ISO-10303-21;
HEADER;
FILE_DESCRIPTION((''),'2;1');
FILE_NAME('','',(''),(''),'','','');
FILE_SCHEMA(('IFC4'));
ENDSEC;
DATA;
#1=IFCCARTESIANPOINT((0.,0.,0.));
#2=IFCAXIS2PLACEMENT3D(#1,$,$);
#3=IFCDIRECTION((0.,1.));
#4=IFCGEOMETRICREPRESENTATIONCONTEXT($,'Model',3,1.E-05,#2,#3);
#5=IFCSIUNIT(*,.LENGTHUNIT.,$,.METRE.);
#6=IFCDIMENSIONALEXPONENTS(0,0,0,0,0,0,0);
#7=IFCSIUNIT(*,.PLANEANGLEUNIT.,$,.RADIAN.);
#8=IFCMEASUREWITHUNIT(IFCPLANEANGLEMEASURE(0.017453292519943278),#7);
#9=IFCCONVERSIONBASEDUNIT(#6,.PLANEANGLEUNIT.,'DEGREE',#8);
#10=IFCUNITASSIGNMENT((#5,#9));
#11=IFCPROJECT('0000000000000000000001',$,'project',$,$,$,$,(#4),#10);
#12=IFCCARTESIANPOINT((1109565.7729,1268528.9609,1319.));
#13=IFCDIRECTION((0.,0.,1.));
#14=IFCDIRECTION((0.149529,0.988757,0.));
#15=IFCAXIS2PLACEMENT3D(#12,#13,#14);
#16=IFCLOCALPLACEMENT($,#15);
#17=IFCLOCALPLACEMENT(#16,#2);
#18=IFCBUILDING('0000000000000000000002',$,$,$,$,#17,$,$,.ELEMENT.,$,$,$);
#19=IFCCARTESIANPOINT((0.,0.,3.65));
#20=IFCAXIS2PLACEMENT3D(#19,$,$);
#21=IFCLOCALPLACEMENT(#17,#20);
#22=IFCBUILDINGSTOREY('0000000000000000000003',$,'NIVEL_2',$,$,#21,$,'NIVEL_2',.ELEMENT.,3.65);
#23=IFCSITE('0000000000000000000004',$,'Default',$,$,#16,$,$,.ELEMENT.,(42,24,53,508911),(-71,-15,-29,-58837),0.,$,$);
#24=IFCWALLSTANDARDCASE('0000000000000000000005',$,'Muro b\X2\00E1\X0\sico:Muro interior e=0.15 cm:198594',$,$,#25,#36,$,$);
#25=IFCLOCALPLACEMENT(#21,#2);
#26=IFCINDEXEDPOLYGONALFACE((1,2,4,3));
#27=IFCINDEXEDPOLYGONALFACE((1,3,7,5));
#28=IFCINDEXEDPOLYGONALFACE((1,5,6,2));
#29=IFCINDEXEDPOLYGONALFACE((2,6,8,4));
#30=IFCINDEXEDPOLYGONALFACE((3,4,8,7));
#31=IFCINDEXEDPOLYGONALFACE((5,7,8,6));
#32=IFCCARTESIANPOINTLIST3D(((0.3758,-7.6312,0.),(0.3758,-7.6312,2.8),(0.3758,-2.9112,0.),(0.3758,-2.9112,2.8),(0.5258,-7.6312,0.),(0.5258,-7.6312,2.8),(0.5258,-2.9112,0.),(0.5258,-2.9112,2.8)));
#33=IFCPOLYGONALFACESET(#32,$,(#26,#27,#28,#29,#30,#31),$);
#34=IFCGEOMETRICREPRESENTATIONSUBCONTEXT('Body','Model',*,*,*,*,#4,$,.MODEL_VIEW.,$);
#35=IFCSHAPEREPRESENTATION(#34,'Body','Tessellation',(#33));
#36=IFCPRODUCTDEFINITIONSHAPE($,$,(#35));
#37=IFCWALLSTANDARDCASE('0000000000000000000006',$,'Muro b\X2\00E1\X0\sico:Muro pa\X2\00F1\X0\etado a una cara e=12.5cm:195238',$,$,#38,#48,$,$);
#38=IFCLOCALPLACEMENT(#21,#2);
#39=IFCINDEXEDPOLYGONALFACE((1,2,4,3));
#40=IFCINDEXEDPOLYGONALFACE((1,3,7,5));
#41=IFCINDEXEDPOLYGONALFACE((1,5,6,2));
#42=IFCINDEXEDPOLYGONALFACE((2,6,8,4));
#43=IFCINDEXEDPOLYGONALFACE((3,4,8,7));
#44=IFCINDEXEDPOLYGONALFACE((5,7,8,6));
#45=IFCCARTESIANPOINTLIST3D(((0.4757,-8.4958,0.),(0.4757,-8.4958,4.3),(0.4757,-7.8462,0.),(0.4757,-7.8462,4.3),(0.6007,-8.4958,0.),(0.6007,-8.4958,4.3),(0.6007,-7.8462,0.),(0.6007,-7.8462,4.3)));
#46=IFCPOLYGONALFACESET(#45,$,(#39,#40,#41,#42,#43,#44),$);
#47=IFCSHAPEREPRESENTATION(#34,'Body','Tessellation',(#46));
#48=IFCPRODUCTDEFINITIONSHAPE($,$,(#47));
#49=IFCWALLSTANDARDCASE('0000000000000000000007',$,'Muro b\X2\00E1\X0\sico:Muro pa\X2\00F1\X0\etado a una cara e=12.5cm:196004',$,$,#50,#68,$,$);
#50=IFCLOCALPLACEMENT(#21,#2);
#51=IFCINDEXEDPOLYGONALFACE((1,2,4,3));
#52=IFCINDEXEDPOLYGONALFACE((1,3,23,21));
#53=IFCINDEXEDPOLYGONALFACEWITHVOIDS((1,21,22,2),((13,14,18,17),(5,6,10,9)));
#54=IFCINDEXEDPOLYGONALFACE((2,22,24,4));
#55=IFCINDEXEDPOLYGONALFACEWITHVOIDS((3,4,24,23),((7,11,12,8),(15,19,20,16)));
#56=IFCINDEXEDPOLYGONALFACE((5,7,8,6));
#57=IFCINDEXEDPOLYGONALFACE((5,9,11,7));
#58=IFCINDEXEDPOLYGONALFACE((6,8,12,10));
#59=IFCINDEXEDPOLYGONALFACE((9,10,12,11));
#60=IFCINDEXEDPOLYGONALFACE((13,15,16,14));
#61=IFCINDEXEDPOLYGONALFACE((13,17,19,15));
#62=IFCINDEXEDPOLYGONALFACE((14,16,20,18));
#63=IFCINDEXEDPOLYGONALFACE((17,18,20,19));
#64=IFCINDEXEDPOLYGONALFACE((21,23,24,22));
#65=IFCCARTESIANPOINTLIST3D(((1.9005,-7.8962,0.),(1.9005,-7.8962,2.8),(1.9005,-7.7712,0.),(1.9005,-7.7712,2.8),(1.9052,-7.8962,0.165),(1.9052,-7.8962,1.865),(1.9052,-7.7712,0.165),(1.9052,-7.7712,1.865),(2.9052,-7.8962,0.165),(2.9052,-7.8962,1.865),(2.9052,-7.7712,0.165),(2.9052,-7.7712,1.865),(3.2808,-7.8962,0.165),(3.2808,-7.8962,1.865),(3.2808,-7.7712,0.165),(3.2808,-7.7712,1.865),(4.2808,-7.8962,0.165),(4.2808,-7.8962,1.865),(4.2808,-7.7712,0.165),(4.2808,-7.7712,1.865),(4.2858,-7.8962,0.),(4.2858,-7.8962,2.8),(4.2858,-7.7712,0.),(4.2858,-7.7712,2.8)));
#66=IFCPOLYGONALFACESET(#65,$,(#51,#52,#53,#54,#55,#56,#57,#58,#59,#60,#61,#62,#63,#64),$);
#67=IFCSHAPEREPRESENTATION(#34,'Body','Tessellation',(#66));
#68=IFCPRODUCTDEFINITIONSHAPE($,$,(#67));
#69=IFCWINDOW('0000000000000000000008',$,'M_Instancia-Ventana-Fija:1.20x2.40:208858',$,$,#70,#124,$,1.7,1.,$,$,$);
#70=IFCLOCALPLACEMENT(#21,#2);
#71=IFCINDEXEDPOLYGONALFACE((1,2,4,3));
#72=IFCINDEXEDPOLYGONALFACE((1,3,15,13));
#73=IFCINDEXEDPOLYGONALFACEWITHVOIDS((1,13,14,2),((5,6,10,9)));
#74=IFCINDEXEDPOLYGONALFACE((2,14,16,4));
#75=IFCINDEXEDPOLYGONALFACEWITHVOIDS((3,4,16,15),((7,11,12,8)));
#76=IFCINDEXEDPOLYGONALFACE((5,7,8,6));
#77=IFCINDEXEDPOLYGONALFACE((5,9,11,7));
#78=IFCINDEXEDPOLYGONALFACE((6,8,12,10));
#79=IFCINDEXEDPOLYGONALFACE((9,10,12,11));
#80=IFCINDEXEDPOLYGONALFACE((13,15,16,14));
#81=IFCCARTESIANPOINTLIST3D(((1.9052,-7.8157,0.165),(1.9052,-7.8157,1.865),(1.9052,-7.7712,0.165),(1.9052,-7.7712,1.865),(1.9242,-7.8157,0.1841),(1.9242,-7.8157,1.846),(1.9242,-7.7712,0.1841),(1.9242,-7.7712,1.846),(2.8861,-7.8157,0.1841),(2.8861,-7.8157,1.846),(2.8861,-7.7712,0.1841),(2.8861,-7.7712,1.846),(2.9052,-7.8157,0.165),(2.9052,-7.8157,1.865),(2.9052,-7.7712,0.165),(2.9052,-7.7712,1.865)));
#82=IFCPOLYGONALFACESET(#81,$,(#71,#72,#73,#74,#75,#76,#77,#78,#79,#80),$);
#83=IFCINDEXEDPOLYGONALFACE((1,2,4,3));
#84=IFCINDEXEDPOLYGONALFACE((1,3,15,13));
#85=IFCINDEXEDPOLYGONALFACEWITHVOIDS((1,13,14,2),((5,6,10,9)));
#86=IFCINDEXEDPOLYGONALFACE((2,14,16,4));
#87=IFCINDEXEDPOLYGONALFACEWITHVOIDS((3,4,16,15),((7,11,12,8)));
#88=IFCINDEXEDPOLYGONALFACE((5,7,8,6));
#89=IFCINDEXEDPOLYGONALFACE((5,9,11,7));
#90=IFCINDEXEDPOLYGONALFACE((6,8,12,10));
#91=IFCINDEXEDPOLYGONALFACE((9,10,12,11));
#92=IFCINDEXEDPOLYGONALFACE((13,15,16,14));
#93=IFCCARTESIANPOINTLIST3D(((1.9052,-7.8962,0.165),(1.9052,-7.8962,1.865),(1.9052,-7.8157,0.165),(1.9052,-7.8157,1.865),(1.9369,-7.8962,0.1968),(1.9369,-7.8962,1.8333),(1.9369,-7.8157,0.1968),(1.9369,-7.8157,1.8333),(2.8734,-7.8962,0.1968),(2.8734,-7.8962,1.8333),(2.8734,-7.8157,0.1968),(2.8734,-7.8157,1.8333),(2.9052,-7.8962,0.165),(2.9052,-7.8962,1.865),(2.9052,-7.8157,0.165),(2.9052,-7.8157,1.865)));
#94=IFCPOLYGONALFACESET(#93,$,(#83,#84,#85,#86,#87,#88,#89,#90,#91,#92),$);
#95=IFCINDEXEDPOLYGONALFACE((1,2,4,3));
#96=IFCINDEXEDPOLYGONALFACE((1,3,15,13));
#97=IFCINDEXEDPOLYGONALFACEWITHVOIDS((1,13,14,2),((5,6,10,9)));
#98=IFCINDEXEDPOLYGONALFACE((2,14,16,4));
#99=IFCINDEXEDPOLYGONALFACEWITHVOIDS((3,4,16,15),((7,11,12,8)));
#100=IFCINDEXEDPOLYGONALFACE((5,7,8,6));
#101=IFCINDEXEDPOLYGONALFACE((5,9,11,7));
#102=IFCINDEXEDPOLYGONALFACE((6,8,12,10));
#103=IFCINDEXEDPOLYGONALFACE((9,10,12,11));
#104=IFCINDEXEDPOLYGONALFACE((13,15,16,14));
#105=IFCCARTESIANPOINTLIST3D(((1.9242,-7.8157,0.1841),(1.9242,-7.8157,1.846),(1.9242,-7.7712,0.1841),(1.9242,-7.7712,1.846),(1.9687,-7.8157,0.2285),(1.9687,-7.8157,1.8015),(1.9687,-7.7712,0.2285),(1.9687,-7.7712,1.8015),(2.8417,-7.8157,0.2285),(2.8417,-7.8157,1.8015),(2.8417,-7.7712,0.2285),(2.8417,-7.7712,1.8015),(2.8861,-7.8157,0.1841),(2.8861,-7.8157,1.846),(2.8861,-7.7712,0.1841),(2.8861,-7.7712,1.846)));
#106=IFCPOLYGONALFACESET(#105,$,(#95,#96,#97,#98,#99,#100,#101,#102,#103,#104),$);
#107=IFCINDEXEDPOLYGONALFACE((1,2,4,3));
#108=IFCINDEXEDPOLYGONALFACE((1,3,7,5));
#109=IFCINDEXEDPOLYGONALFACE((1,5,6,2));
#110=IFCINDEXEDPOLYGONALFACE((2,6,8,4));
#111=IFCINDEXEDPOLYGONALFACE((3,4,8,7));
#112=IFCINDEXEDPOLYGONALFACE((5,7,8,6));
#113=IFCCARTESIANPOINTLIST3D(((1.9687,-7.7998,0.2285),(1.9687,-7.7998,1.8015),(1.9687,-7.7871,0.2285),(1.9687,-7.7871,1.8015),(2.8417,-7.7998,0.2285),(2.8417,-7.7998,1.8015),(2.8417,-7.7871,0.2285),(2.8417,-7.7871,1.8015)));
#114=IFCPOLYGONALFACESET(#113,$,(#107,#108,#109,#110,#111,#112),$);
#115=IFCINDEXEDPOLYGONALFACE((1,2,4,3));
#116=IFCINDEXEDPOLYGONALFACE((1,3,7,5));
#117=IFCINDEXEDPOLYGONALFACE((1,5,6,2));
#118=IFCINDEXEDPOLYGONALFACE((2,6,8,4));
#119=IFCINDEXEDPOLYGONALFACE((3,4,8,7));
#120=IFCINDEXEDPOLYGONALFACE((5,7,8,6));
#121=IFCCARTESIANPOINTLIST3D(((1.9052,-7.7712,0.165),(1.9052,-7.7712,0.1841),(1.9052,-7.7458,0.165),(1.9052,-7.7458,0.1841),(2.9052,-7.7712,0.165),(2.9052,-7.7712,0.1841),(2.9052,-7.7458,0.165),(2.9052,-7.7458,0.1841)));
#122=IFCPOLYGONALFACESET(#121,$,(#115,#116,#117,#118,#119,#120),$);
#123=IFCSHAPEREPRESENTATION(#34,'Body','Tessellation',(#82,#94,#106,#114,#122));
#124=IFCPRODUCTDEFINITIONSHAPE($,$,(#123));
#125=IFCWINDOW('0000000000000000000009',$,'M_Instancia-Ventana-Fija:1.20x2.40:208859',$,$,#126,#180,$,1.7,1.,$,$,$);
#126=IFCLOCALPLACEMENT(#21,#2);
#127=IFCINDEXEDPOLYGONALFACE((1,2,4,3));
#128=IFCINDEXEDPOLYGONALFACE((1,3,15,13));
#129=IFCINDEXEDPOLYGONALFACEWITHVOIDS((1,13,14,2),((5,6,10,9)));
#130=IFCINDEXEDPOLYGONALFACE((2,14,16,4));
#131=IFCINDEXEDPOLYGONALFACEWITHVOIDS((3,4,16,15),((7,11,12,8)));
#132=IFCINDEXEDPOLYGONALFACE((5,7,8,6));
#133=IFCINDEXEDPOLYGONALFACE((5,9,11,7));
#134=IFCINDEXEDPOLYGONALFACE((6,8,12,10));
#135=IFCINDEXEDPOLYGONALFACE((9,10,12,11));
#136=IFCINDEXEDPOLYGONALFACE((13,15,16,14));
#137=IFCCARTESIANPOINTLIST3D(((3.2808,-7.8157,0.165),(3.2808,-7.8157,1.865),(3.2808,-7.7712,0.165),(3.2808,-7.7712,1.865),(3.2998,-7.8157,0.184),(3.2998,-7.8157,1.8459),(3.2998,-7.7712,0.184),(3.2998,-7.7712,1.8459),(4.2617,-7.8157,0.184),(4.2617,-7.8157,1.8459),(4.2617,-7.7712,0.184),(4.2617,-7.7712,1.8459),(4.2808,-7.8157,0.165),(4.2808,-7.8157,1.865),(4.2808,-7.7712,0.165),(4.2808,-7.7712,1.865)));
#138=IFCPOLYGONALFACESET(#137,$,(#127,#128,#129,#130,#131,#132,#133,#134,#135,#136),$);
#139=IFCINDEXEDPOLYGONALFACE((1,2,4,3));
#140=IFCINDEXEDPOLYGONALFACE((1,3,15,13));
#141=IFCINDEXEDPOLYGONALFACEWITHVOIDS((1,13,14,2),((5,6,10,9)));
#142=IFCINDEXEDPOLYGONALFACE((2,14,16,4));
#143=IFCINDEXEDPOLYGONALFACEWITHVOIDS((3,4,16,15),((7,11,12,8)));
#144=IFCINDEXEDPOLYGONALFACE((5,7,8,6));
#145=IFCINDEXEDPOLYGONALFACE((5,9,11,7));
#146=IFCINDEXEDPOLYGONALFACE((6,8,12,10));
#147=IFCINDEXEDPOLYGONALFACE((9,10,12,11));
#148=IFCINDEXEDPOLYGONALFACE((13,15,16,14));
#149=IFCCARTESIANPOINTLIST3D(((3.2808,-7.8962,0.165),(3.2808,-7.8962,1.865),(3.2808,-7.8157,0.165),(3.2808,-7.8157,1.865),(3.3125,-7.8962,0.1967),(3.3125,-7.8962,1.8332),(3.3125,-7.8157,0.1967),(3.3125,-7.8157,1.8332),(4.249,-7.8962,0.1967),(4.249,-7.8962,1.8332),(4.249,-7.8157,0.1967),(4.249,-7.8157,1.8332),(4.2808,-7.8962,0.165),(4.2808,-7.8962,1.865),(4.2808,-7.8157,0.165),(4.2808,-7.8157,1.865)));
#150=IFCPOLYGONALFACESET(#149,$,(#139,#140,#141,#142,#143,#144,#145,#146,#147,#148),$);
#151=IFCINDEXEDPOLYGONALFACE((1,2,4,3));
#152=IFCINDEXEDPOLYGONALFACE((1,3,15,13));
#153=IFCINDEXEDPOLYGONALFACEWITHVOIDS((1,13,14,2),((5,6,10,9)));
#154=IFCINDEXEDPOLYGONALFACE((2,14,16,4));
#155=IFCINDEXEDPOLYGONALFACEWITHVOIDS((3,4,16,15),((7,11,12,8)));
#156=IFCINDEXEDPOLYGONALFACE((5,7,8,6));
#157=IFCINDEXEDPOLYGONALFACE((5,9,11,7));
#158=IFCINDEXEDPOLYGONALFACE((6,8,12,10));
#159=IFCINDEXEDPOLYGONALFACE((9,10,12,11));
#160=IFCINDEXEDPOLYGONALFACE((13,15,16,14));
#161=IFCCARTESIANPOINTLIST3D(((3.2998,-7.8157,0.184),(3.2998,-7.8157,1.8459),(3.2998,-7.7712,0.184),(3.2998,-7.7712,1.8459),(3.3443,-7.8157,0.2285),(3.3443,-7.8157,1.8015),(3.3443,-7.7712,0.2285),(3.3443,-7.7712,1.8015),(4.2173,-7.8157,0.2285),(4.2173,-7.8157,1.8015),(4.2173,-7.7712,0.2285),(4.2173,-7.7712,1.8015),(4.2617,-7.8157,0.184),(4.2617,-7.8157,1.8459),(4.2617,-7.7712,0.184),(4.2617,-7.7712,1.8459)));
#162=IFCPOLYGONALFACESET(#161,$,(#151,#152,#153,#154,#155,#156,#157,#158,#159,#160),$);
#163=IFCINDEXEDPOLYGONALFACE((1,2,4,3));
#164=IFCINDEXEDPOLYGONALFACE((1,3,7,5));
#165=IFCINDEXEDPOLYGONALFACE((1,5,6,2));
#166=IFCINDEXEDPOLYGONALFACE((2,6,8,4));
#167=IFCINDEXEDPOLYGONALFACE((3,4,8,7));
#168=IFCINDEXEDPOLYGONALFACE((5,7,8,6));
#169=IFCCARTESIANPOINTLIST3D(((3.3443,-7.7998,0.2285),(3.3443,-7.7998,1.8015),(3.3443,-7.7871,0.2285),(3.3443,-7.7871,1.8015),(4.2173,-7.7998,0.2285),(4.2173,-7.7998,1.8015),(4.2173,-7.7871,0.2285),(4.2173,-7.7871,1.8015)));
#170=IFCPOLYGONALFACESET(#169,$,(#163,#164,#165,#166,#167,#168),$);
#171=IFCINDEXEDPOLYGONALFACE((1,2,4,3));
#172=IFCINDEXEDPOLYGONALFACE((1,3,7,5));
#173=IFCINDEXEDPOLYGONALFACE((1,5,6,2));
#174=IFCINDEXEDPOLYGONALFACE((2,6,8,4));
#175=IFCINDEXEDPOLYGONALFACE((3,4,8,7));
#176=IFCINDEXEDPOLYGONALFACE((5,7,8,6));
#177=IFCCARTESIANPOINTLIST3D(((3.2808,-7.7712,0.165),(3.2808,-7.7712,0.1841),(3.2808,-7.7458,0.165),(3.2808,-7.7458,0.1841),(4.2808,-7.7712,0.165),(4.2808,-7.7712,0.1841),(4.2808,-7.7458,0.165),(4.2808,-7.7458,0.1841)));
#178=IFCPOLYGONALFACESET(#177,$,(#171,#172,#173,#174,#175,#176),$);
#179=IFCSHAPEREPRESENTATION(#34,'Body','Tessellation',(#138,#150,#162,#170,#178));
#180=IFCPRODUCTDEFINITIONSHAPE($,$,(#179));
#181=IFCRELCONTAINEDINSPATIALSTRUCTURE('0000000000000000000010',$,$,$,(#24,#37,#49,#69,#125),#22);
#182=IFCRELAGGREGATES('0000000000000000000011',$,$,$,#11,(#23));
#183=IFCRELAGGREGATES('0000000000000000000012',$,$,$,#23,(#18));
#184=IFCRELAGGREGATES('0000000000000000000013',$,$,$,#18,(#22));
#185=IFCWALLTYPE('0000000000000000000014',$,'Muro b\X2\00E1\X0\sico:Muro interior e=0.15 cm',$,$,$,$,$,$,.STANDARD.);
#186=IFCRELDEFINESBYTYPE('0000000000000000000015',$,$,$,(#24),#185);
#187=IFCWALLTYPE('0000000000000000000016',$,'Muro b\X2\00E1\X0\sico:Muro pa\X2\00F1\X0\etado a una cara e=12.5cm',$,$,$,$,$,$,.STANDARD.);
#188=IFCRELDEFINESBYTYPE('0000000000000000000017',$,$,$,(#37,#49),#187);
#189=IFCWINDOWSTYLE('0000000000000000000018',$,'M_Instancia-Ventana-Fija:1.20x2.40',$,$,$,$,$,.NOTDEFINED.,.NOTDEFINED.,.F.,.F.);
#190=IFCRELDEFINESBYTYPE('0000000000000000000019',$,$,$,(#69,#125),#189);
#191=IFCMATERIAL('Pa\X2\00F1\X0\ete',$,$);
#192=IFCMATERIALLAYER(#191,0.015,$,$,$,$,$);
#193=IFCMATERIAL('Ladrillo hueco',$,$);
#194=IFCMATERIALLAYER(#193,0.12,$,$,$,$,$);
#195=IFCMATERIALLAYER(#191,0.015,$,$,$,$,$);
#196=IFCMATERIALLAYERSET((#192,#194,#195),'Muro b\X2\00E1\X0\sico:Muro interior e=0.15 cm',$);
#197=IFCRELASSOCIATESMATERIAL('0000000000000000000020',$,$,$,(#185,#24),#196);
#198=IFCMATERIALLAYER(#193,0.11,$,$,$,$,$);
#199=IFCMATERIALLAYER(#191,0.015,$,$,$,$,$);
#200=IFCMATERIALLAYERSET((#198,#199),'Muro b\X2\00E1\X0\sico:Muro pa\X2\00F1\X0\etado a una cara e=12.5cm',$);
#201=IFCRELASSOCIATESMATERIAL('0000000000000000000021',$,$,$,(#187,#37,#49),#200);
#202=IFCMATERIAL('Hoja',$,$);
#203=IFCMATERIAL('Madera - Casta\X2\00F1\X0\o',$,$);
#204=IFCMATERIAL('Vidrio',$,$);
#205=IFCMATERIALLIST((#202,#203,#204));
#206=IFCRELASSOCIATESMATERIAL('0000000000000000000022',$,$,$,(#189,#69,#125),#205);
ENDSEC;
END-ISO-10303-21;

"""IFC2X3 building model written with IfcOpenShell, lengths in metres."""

from ifc_helpers import new_model, entity, si_unit, converted_unit, direction, frame, frame_2d, origin, origin_2d_with_axis, place, context, subcontext, project, spatial, polyline, rectangle, outline, extrude, source, transform, mapped, material, material_list, layer, layer_set, layer_usage, type_object, type_shapes, element, fill, save


model = new_model("IFC2X3")

# Units and contexts
model_context = context("Model", 3, precision=1e-05, world=origin(), true_north=direction((0.0, 1.0)))
body_context = subcontext(model_context, "Body", "Model", "MODEL_VIEW")
ifc_project = project(units=[si_unit("LENGTHUNIT", "METRE"), converted_unit("PLANEANGLEUNIT", "DEGREE", entity("IfcPlaneAngleMeasure", 0.017453292519943278), si_unit("PLANEANGLEUNIT", "RADIAN"), dimensions=[0, 0, 0, 0, 0, 0, 0])], contexts=[model_context])

# Site, building, storey
site_placement = place(None, frame((1109565.7729, 1268528.9609, 1319.0), z_axis=(0.0, 0.0, 1.0), x_axis=(0.149529, 0.988757, 0.0)))
site = spatial("IfcSite", under=ifc_project, at=site_placement, Name="Default", CompositionType="ELEMENT", RefLatitude=(42, 24, 53, 508911), RefLongitude=(-71, -15, -29, -58837), RefElevation=0.0)
building_placement = place(site_placement, origin())
building = spatial("IfcBuilding", under=site, at=building_placement, CompositionType="ELEMENT")
storey_placement = place(building_placement, frame((0.0, 0.0, 3.65)))
storey = spatial("IfcBuildingStorey", under=building, at=storey_placement, Name="NIVEL_2", LongName="NIVEL_2", CompositionType="ELEMENT", Elevation=3.65)

# Walls
ifc_material_1 = material(Name="Pañete")
ifc_layer_1 = layer(ifc_material_1, 0.015)
ifc_material_2 = material(Name="Ladrillo hueco")
ifc_layer_2 = layer(ifc_material_2, 0.12)
ifc_layer_3 = layer(ifc_material_1, 0.015)
ifc_layer_set_1 = layer_set([ifc_layer_1, ifc_layer_2, ifc_layer_3], Name="Muro básico:Muro interior e=0.15 cm")
ifc_layer_usage_1 = layer_usage(ifc_layer_set_1, "AXIS2", "NEGATIVE", 0.075)
wall_type_1 = type_object("IfcWallType", Name="Muro básico:Muro interior e=0.15 cm", PredefinedType="STANDARD", material=ifc_layer_set_1)
wall_1_placement = place(storey_placement, frame((0.4508, -7.6312, 0.0), z_axis=(0.0, 0.0, 1.0), x_axis=(0.0, 1.0, 0.0)))
element("IfcWallStandardCase", 1, at=wall_1_placement, inside=storey, type_object=wall_type_1, material=ifc_layer_usage_1, Name="Muro básico:Muro interior e=0.15 cm:198594", context=body_context, shape_type="SweptSolid", body=[
    extrude(rectangle(XDim=4.72, YDim=0.15, at=frame_2d((2.36, 0.0), x_axis=(-1.0, 0.0))), origin(), (0.0, 0.0, 1.0), 2.8),
])
ifc_layer_4 = layer(ifc_material_2, 0.11)
ifc_layer_5 = layer(ifc_material_1, 0.015)
ifc_layer_set_2 = layer_set([ifc_layer_4, ifc_layer_5], Name="Muro básico:Muro pañetado a una cara e=12.5cm")
ifc_layer_usage_2 = layer_usage(ifc_layer_set_2, "AXIS2", "POSITIVE", -0.0625)
wall_type_2 = type_object("IfcWallType", Name="Muro básico:Muro pañetado a una cara e=12.5cm", PredefinedType="STANDARD", material=ifc_layer_set_2)
wall_2_placement = place(storey_placement, frame((0.5382, -8.4958, 0.0), z_axis=(0.0, 0.0, 1.0), x_axis=(0.0, 1.0, 0.0)))
element("IfcWallStandardCase", 2, at=wall_2_placement, inside=storey, type_object=wall_type_2, material=ifc_layer_usage_2, Name="Muro básico:Muro pañetado a una cara e=12.5cm:195238", context=body_context, shape_type="SweptSolid", body=[
    extrude(rectangle(XDim=0.6496, YDim=0.125, at=frame_2d((0.3248, 0.0), x_axis=(-1.0, 0.0))), origin(), (0.0, 0.0, 1.0), 4.3),
])

# Wall, openings, windows
ifc_layer_usage_3 = layer_usage(ifc_layer_set_2, "AXIS2", "POSITIVE", -0.0625)
wall_3_placement = place(storey_placement, frame((1.9005, -7.8337, 0.0)))
wall_3 = element("IfcWallStandardCase", 3, at=wall_3_placement, inside=storey, type_object=wall_type_2, material=ifc_layer_usage_3, Name="Muro básico:Muro pañetado a una cara e=12.5cm:196004", context=body_context, shape_type="SweptSolid", body=[
    extrude(rectangle(XDim=2.3853, YDim=0.125, at=frame_2d((1.1927, 0.0), x_axis=(-1.0, 0.0))), origin(), (0.0, 0.0, 1.0), 2.8),
])
opening_1_placement = place(wall_3_placement, frame((1.3803, -0.0625, 0.165)))
opening_1 = element("IfcOpeningElement", 4, at=opening_1_placement, cuts=wall_3, ObjectType="Opening", context=body_context, shape_type="SweptSolid", body=[
    extrude(rectangle(XDim=1.7, YDim=1.0, at=frame_2d((0.85, 0.5), x_axis=(-1.0, 0.0))), frame((0.0, 0.0, 0.0), z_axis=(0.0, 1.0, 0.0), x_axis=(0.0, 0.0, 1.0)), (0.0, 0.0, 1.0), 0.125),
])
opening_2_placement = place(wall_3_placement, frame((0.0047, -0.0625, 0.165)))
opening_2 = element("IfcOpeningElement", 5, at=opening_2_placement, cuts=wall_3, ObjectType="Opening", context=body_context, shape_type="SweptSolid", body=[
    extrude(rectangle(XDim=1.7, YDim=1.0, at=frame_2d((0.85, 0.5), x_axis=(-1.0, 0.0))), frame((0.0, 0.0, 0.0), z_axis=(0.0, 1.0, 0.0), x_axis=(0.0, 0.0, 1.0)), (0.0, 0.0, 1.0), 0.125),
])
ifc_material_3 = material(Name="Hoja")
ifc_material_4 = material(Name="Madera - Castaño")
ifc_material_5 = material(Name="Vidrio")
ifc_material_list = material_list([ifc_material_3, ifc_material_4, ifc_material_5])
window_style = type_object("IfcWindowStyle", Name="M_Instancia-Ventana-Fija:1.20x2.40", ConstructionType="NOTDEFINED", OperationType="NOTDEFINED", ParameterTakesPrecedence=False, Sizeable=False, material=ifc_material_list)
shared_shape = source(origin(), body_context, "Body", "SweptSolid", [
    extrude(outline(polyline([(-0.85, -0.5), (0.85, -0.5), (0.85, 0.5), (-0.85, 0.5), (-0.85, -0.5)]), holes=[polyline([(-0.8309, -0.4809), (-0.8309, 0.481), (0.831, 0.481), (0.831, -0.4809), (-0.8309, -0.4809)])]), frame((0.5, 0.0806, 0.85), z_axis=(0.0, 1.0, 0.0), x_axis=(0.0, 0.0, -1.0)), (0.0, 0.0, 1.0), 0.0444),
    extrude(outline(polyline([(-0.5, -0.85), (0.5, -0.85), (0.5, 0.85), (-0.5, 0.85), (-0.5, -0.85)]), holes=[polyline([(-0.4683, -0.8182), (-0.4683, 0.8183), (0.4682, 0.8183), (0.4682, -0.8182), (-0.4683, -0.8182)])]), frame((0.5, 0.0, 0.85), z_axis=(0.0, 1.0, 0.0), x_axis=(1.0, 0.0, 0.0)), (0.0, 0.0, 1.0), 0.0806),
    extrude(outline(polyline([(-0.4809, -0.831), (0.4809, -0.831), (0.4809, 0.831), (-0.4809, 0.831), (-0.4809, -0.831)]), holes=[polyline([(-0.4365, -0.7865), (-0.4365, 0.7865), (0.4365, 0.7865), (0.4365, -0.7865), (-0.4365, -0.7865)])]), frame((0.5, 0.0806, 0.85), z_axis=(0.0, 1.0, 0.0), x_axis=(1.0, 0.0, 0.0)), (0.0, 0.0, 1.0), 0.0444),
    extrude(rectangle(XDim=0.0127, YDim=0.873, at=frame_2d((0.0, 0.0), x_axis=(1.0, 0.0))), frame((0.5, 0.1028, 0.0635), z_axis=(0.0, 0.0, 1.0), x_axis=(0.0, 1.0, 0.0)), (0.0, 0.0, 1.0), 1.573),
    extrude(rectangle(XDim=0.0254, YDim=1.0, at=origin_2d_with_axis()), frame((0.5, 0.1377, 0.0), z_axis=(0.0, 0.0, 1.0), x_axis=(0.0, -1.0, 0.0)), (0.0, 0.0, 1.0), 0.019),
])
type_shapes(window_style, [shared_shape])
window_1_placement = place(opening_2_placement, origin())
window_1 = element("IfcWindow", 6, at=window_1_placement, inside=storey, type_object=window_style, material=ifc_material_list, Name="M_Instancia-Ventana-Fija:1.20x2.40:208858", OverallHeight=1.7, OverallWidth=1.0, context=body_context, shape_type="MappedRepresentation", body=[
    mapped(shared_shape, transform((0.0, 0.0, 0.0), scale=1.0)),
])
fill(opening_2, window_1)
window_2_placement = place(opening_1_placement, origin())
window_2 = element("IfcWindow", 7, at=window_2_placement, inside=storey, type_object=window_style, material=ifc_material_list, Name="M_Instancia-Ventana-Fija:1.20x2.40:208859", OverallHeight=1.7, OverallWidth=1.0, context=body_context, shape_type="MappedRepresentation", body=[
    mapped(shared_shape, transform((0.0, 0.0, 0.0), scale=1.0)),
])
fill(opening_1, window_2)

save(model, "model.ifc")
